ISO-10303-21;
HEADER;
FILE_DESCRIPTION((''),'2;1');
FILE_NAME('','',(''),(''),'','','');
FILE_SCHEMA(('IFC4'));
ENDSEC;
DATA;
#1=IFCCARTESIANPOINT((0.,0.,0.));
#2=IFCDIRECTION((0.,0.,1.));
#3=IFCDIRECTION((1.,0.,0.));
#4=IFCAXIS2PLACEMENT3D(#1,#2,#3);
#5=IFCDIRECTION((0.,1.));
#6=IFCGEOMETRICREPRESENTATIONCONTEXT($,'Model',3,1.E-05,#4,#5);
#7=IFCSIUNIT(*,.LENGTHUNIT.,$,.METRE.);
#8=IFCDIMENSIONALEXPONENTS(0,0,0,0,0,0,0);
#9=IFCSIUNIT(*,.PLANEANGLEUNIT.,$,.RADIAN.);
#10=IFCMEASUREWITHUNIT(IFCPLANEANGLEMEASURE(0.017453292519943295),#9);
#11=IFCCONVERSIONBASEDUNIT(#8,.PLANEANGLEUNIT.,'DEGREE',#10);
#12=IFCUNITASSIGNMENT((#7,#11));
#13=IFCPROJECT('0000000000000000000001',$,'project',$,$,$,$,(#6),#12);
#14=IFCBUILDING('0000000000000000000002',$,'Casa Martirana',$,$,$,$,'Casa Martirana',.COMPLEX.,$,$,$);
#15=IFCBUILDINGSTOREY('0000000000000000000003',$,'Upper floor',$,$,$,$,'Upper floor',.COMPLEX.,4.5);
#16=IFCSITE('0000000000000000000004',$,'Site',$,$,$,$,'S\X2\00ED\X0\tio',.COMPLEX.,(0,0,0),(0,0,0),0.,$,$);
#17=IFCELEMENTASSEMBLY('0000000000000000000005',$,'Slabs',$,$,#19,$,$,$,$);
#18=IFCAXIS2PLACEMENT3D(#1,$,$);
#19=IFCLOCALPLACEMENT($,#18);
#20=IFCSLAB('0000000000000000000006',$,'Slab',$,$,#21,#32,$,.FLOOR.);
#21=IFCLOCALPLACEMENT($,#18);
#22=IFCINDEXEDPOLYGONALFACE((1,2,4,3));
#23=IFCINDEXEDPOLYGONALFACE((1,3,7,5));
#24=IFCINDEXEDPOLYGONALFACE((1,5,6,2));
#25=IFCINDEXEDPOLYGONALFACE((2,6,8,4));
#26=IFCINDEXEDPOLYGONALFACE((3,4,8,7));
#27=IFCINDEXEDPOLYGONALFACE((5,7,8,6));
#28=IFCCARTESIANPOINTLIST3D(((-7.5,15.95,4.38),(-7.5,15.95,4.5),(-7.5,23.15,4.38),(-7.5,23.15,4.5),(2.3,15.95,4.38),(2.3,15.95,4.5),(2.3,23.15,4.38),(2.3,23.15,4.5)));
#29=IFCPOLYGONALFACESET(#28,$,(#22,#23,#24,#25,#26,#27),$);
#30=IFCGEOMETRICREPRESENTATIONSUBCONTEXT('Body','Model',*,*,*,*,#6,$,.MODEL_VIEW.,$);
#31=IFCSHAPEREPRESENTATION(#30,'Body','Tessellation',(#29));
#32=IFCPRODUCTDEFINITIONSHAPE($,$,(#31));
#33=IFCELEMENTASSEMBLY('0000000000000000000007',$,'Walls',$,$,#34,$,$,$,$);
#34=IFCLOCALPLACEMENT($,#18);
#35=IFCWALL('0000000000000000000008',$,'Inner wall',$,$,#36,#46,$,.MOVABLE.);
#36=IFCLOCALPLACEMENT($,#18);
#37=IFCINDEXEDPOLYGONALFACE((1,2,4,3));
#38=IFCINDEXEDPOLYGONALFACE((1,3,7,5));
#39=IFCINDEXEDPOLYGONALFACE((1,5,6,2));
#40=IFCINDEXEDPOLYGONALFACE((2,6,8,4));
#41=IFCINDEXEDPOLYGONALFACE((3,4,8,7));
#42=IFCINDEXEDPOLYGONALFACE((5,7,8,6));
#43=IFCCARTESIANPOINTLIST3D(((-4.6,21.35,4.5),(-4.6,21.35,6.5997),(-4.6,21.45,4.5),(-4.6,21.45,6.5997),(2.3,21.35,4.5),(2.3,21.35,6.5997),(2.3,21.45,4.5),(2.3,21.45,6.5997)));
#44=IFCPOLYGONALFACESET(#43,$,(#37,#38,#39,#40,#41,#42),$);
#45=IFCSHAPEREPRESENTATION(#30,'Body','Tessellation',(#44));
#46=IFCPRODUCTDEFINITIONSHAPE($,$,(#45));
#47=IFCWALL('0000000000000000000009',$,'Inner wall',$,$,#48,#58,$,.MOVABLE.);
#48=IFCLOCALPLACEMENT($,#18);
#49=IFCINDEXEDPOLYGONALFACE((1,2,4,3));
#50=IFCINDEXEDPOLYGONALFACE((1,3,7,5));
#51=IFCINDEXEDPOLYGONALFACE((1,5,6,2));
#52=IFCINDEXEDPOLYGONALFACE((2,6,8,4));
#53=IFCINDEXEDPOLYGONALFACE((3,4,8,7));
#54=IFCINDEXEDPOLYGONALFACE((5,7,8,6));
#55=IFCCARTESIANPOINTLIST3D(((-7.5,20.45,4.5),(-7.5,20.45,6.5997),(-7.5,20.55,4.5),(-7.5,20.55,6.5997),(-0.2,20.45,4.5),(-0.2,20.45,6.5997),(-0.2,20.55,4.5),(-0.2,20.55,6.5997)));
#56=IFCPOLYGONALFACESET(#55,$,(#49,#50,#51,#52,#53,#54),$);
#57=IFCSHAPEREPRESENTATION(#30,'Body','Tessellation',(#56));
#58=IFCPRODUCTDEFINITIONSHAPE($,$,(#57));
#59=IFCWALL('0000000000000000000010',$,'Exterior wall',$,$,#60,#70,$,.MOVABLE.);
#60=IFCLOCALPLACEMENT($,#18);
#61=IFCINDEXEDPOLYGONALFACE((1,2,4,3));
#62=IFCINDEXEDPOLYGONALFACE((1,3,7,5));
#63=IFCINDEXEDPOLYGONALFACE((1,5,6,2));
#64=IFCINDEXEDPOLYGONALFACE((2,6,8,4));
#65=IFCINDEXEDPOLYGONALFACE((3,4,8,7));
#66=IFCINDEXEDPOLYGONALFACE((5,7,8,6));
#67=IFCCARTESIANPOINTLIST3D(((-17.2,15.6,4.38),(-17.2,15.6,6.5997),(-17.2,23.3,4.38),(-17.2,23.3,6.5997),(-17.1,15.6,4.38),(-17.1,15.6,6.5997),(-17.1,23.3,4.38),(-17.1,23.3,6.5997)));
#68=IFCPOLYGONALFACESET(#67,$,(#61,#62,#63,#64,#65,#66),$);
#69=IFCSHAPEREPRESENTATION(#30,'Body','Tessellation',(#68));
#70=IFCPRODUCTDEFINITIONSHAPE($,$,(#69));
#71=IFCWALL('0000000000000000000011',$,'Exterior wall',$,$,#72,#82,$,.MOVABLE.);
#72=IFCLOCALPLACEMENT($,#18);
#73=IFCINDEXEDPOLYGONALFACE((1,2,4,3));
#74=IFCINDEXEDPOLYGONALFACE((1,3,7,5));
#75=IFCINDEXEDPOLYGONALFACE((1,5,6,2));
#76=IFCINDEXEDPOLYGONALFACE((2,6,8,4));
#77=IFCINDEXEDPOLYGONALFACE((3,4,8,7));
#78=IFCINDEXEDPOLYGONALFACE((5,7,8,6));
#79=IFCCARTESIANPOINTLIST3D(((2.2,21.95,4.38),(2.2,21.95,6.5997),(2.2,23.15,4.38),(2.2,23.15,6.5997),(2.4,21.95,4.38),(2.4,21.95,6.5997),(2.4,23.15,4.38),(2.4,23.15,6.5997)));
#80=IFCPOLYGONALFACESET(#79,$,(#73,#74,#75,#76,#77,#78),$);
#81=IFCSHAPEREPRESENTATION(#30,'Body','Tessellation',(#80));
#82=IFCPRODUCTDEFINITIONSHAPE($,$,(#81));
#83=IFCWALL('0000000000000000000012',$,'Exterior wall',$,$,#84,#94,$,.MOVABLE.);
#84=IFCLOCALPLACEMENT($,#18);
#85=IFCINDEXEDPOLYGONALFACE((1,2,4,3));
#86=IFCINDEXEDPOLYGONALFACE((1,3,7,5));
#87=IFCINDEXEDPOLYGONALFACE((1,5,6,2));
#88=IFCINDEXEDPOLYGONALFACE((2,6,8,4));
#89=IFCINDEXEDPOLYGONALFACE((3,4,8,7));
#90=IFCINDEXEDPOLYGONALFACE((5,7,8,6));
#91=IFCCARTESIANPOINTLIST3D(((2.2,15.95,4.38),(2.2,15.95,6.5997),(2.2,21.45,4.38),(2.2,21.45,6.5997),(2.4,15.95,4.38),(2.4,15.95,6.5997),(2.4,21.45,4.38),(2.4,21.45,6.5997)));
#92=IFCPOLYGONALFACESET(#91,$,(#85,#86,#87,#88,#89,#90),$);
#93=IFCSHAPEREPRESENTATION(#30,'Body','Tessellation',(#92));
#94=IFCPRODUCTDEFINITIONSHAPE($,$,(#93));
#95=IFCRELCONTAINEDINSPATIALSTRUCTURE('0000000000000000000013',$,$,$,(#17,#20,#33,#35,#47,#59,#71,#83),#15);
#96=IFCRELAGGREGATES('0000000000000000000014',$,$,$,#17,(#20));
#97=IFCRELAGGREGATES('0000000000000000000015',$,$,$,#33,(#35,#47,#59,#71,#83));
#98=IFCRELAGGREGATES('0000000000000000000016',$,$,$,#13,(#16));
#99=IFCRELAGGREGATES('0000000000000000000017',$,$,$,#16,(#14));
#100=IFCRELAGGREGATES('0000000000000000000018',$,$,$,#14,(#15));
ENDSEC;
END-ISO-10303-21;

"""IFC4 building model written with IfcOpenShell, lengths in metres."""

from ifc_helpers import new_model, entity, si_unit, converted_unit, direction, frame, frame_2d, origin_with_axes, origin_2d_with_axis, place, context, subcontext, project, spatial, rectangle, extrude, element, aggregate, save


model = new_model("IFC4")

# Units and contexts
model_context = context("Model", 3, precision=1e-05, world=origin_with_axes(), true_north=direction((0.0, 1.0)))
body_context = subcontext(model_context, "Body", "Model", "MODEL_VIEW")
ifc_project = project(units=[si_unit("LENGTHUNIT", "METRE"), converted_unit("PLANEANGLEUNIT", "DEGREE", entity("IfcPlaneAngleMeasure", 0.017453292519943295), si_unit("PLANEANGLEUNIT", "RADIAN"), dimensions=[0, 0, 0, 0, 0, 0, 0])], contexts=[model_context])

# Site, building, storey
site = spatial("IfcSite", under=ifc_project, Name="Site", LongName="Sítio", CompositionType="COMPLEX", RefLatitude=(0, 0, 0), RefLongitude=(0, 0, 0), RefElevation=0.0)
building = spatial("IfcBuilding", under=site, Name="Casa Martirana", LongName="Casa Martirana", CompositionType="COMPLEX")
storey = spatial("IfcBuildingStorey", under=building, Name="Upper floor", LongName="Upper floor", CompositionType="COMPLEX", Elevation=4.5)

# Element assembly, slab
assembly_1 = element("IfcElementAssembly", 1, inside=storey, Name="Slabs")
placement = place(None, origin_with_axes())
slab = element("IfcSlab", 2, at=placement, inside=storey, Name="Slab", PredefinedType="FLOOR", context=body_context, shape_type="SweptSolid", body=[
    extrude(rectangle(XDim=9.8, YDim=7.2, at=origin_2d_with_axis()), frame((-2.6, 19.55, 4.5), z_axis=(0.0, 0.0, 1.0), x_axis=(1.0, 0.0, 0.0)), (0.0, 0.0, -1.0), 0.12),
])
aggregate(assembly_1, [slab])

# Element assembly, walls
assembly_2 = element("IfcElementAssembly", 3, inside=storey, Name="Walls")
wall_1 = element("IfcWall", 4, at=placement, inside=storey, Name="Inner wall", PredefinedType="MOVABLE", context=body_context, shape_type="SweptSolid", body=[
    extrude(rectangle(XDim=6.9, YDim=0.1, at=origin_2d_with_axis()), frame((-1.15, 21.4, 4.5), z_axis=(0.0, 0.0, 1.0), x_axis=(1.0, 0.0, 0.0)), (0.0, 0.0, 1.0), 2.0997),
])
wall_2 = element("IfcWall", 5, at=placement, inside=storey, Name="Inner wall", PredefinedType="MOVABLE", context=body_context, shape_type="SweptSolid", body=[
    extrude(rectangle(XDim=7.3, YDim=0.1, at=origin_2d_with_axis()), frame((-3.85, 20.5, 4.5), z_axis=(0.0, 0.0, 1.0), x_axis=(1.0, 0.0, 0.0)), (0.0, 0.0, 1.0), 2.0997),
])
wall_3 = element("IfcWall", 6, at=placement, inside=storey, Name="Exterior wall", PredefinedType="MOVABLE", context=body_context, shape_type="SweptSolid", body=[
    extrude(rectangle(XDim=7.7, YDim=0.1, at=frame_2d((0.0, 0.0), x_axis=(0.0, 1.0))), frame((-17.15, 19.45, 4.38), z_axis=(0.0, 0.0, 1.0), x_axis=(1.0, 0.0, 0.0)), (0.0, 0.0, 1.0), 2.2197),
])
wall_4 = element("IfcWall", 7, at=placement, inside=storey, Name="Exterior wall", PredefinedType="MOVABLE", context=body_context, shape_type="SweptSolid", body=[
    extrude(rectangle(XDim=1.2, YDim=0.2, at=frame_2d((0.0, 0.0), x_axis=(0.0, 1.0))), frame((2.3, 22.55, 4.38), z_axis=(0.0, 0.0, 1.0), x_axis=(1.0, 0.0, 0.0)), (0.0, 0.0, 1.0), 2.2197),
])
wall_5 = element("IfcWall", 8, at=placement, inside=storey, Name="Exterior wall", PredefinedType="MOVABLE", context=body_context, shape_type="SweptSolid", body=[
    extrude(rectangle(XDim=5.5, YDim=0.2, at=frame_2d((0.0, 0.0), x_axis=(0.0, 1.0))), frame((2.3, 18.7, 4.38), z_axis=(0.0, 0.0, 1.0), x_axis=(1.0, 0.0, 0.0)), (0.0, 0.0, 1.0), 2.2197),
])
aggregate(assembly_2, [wall_1, wall_2, wall_3, wall_4, wall_5])

save(model, "model.ifc")
